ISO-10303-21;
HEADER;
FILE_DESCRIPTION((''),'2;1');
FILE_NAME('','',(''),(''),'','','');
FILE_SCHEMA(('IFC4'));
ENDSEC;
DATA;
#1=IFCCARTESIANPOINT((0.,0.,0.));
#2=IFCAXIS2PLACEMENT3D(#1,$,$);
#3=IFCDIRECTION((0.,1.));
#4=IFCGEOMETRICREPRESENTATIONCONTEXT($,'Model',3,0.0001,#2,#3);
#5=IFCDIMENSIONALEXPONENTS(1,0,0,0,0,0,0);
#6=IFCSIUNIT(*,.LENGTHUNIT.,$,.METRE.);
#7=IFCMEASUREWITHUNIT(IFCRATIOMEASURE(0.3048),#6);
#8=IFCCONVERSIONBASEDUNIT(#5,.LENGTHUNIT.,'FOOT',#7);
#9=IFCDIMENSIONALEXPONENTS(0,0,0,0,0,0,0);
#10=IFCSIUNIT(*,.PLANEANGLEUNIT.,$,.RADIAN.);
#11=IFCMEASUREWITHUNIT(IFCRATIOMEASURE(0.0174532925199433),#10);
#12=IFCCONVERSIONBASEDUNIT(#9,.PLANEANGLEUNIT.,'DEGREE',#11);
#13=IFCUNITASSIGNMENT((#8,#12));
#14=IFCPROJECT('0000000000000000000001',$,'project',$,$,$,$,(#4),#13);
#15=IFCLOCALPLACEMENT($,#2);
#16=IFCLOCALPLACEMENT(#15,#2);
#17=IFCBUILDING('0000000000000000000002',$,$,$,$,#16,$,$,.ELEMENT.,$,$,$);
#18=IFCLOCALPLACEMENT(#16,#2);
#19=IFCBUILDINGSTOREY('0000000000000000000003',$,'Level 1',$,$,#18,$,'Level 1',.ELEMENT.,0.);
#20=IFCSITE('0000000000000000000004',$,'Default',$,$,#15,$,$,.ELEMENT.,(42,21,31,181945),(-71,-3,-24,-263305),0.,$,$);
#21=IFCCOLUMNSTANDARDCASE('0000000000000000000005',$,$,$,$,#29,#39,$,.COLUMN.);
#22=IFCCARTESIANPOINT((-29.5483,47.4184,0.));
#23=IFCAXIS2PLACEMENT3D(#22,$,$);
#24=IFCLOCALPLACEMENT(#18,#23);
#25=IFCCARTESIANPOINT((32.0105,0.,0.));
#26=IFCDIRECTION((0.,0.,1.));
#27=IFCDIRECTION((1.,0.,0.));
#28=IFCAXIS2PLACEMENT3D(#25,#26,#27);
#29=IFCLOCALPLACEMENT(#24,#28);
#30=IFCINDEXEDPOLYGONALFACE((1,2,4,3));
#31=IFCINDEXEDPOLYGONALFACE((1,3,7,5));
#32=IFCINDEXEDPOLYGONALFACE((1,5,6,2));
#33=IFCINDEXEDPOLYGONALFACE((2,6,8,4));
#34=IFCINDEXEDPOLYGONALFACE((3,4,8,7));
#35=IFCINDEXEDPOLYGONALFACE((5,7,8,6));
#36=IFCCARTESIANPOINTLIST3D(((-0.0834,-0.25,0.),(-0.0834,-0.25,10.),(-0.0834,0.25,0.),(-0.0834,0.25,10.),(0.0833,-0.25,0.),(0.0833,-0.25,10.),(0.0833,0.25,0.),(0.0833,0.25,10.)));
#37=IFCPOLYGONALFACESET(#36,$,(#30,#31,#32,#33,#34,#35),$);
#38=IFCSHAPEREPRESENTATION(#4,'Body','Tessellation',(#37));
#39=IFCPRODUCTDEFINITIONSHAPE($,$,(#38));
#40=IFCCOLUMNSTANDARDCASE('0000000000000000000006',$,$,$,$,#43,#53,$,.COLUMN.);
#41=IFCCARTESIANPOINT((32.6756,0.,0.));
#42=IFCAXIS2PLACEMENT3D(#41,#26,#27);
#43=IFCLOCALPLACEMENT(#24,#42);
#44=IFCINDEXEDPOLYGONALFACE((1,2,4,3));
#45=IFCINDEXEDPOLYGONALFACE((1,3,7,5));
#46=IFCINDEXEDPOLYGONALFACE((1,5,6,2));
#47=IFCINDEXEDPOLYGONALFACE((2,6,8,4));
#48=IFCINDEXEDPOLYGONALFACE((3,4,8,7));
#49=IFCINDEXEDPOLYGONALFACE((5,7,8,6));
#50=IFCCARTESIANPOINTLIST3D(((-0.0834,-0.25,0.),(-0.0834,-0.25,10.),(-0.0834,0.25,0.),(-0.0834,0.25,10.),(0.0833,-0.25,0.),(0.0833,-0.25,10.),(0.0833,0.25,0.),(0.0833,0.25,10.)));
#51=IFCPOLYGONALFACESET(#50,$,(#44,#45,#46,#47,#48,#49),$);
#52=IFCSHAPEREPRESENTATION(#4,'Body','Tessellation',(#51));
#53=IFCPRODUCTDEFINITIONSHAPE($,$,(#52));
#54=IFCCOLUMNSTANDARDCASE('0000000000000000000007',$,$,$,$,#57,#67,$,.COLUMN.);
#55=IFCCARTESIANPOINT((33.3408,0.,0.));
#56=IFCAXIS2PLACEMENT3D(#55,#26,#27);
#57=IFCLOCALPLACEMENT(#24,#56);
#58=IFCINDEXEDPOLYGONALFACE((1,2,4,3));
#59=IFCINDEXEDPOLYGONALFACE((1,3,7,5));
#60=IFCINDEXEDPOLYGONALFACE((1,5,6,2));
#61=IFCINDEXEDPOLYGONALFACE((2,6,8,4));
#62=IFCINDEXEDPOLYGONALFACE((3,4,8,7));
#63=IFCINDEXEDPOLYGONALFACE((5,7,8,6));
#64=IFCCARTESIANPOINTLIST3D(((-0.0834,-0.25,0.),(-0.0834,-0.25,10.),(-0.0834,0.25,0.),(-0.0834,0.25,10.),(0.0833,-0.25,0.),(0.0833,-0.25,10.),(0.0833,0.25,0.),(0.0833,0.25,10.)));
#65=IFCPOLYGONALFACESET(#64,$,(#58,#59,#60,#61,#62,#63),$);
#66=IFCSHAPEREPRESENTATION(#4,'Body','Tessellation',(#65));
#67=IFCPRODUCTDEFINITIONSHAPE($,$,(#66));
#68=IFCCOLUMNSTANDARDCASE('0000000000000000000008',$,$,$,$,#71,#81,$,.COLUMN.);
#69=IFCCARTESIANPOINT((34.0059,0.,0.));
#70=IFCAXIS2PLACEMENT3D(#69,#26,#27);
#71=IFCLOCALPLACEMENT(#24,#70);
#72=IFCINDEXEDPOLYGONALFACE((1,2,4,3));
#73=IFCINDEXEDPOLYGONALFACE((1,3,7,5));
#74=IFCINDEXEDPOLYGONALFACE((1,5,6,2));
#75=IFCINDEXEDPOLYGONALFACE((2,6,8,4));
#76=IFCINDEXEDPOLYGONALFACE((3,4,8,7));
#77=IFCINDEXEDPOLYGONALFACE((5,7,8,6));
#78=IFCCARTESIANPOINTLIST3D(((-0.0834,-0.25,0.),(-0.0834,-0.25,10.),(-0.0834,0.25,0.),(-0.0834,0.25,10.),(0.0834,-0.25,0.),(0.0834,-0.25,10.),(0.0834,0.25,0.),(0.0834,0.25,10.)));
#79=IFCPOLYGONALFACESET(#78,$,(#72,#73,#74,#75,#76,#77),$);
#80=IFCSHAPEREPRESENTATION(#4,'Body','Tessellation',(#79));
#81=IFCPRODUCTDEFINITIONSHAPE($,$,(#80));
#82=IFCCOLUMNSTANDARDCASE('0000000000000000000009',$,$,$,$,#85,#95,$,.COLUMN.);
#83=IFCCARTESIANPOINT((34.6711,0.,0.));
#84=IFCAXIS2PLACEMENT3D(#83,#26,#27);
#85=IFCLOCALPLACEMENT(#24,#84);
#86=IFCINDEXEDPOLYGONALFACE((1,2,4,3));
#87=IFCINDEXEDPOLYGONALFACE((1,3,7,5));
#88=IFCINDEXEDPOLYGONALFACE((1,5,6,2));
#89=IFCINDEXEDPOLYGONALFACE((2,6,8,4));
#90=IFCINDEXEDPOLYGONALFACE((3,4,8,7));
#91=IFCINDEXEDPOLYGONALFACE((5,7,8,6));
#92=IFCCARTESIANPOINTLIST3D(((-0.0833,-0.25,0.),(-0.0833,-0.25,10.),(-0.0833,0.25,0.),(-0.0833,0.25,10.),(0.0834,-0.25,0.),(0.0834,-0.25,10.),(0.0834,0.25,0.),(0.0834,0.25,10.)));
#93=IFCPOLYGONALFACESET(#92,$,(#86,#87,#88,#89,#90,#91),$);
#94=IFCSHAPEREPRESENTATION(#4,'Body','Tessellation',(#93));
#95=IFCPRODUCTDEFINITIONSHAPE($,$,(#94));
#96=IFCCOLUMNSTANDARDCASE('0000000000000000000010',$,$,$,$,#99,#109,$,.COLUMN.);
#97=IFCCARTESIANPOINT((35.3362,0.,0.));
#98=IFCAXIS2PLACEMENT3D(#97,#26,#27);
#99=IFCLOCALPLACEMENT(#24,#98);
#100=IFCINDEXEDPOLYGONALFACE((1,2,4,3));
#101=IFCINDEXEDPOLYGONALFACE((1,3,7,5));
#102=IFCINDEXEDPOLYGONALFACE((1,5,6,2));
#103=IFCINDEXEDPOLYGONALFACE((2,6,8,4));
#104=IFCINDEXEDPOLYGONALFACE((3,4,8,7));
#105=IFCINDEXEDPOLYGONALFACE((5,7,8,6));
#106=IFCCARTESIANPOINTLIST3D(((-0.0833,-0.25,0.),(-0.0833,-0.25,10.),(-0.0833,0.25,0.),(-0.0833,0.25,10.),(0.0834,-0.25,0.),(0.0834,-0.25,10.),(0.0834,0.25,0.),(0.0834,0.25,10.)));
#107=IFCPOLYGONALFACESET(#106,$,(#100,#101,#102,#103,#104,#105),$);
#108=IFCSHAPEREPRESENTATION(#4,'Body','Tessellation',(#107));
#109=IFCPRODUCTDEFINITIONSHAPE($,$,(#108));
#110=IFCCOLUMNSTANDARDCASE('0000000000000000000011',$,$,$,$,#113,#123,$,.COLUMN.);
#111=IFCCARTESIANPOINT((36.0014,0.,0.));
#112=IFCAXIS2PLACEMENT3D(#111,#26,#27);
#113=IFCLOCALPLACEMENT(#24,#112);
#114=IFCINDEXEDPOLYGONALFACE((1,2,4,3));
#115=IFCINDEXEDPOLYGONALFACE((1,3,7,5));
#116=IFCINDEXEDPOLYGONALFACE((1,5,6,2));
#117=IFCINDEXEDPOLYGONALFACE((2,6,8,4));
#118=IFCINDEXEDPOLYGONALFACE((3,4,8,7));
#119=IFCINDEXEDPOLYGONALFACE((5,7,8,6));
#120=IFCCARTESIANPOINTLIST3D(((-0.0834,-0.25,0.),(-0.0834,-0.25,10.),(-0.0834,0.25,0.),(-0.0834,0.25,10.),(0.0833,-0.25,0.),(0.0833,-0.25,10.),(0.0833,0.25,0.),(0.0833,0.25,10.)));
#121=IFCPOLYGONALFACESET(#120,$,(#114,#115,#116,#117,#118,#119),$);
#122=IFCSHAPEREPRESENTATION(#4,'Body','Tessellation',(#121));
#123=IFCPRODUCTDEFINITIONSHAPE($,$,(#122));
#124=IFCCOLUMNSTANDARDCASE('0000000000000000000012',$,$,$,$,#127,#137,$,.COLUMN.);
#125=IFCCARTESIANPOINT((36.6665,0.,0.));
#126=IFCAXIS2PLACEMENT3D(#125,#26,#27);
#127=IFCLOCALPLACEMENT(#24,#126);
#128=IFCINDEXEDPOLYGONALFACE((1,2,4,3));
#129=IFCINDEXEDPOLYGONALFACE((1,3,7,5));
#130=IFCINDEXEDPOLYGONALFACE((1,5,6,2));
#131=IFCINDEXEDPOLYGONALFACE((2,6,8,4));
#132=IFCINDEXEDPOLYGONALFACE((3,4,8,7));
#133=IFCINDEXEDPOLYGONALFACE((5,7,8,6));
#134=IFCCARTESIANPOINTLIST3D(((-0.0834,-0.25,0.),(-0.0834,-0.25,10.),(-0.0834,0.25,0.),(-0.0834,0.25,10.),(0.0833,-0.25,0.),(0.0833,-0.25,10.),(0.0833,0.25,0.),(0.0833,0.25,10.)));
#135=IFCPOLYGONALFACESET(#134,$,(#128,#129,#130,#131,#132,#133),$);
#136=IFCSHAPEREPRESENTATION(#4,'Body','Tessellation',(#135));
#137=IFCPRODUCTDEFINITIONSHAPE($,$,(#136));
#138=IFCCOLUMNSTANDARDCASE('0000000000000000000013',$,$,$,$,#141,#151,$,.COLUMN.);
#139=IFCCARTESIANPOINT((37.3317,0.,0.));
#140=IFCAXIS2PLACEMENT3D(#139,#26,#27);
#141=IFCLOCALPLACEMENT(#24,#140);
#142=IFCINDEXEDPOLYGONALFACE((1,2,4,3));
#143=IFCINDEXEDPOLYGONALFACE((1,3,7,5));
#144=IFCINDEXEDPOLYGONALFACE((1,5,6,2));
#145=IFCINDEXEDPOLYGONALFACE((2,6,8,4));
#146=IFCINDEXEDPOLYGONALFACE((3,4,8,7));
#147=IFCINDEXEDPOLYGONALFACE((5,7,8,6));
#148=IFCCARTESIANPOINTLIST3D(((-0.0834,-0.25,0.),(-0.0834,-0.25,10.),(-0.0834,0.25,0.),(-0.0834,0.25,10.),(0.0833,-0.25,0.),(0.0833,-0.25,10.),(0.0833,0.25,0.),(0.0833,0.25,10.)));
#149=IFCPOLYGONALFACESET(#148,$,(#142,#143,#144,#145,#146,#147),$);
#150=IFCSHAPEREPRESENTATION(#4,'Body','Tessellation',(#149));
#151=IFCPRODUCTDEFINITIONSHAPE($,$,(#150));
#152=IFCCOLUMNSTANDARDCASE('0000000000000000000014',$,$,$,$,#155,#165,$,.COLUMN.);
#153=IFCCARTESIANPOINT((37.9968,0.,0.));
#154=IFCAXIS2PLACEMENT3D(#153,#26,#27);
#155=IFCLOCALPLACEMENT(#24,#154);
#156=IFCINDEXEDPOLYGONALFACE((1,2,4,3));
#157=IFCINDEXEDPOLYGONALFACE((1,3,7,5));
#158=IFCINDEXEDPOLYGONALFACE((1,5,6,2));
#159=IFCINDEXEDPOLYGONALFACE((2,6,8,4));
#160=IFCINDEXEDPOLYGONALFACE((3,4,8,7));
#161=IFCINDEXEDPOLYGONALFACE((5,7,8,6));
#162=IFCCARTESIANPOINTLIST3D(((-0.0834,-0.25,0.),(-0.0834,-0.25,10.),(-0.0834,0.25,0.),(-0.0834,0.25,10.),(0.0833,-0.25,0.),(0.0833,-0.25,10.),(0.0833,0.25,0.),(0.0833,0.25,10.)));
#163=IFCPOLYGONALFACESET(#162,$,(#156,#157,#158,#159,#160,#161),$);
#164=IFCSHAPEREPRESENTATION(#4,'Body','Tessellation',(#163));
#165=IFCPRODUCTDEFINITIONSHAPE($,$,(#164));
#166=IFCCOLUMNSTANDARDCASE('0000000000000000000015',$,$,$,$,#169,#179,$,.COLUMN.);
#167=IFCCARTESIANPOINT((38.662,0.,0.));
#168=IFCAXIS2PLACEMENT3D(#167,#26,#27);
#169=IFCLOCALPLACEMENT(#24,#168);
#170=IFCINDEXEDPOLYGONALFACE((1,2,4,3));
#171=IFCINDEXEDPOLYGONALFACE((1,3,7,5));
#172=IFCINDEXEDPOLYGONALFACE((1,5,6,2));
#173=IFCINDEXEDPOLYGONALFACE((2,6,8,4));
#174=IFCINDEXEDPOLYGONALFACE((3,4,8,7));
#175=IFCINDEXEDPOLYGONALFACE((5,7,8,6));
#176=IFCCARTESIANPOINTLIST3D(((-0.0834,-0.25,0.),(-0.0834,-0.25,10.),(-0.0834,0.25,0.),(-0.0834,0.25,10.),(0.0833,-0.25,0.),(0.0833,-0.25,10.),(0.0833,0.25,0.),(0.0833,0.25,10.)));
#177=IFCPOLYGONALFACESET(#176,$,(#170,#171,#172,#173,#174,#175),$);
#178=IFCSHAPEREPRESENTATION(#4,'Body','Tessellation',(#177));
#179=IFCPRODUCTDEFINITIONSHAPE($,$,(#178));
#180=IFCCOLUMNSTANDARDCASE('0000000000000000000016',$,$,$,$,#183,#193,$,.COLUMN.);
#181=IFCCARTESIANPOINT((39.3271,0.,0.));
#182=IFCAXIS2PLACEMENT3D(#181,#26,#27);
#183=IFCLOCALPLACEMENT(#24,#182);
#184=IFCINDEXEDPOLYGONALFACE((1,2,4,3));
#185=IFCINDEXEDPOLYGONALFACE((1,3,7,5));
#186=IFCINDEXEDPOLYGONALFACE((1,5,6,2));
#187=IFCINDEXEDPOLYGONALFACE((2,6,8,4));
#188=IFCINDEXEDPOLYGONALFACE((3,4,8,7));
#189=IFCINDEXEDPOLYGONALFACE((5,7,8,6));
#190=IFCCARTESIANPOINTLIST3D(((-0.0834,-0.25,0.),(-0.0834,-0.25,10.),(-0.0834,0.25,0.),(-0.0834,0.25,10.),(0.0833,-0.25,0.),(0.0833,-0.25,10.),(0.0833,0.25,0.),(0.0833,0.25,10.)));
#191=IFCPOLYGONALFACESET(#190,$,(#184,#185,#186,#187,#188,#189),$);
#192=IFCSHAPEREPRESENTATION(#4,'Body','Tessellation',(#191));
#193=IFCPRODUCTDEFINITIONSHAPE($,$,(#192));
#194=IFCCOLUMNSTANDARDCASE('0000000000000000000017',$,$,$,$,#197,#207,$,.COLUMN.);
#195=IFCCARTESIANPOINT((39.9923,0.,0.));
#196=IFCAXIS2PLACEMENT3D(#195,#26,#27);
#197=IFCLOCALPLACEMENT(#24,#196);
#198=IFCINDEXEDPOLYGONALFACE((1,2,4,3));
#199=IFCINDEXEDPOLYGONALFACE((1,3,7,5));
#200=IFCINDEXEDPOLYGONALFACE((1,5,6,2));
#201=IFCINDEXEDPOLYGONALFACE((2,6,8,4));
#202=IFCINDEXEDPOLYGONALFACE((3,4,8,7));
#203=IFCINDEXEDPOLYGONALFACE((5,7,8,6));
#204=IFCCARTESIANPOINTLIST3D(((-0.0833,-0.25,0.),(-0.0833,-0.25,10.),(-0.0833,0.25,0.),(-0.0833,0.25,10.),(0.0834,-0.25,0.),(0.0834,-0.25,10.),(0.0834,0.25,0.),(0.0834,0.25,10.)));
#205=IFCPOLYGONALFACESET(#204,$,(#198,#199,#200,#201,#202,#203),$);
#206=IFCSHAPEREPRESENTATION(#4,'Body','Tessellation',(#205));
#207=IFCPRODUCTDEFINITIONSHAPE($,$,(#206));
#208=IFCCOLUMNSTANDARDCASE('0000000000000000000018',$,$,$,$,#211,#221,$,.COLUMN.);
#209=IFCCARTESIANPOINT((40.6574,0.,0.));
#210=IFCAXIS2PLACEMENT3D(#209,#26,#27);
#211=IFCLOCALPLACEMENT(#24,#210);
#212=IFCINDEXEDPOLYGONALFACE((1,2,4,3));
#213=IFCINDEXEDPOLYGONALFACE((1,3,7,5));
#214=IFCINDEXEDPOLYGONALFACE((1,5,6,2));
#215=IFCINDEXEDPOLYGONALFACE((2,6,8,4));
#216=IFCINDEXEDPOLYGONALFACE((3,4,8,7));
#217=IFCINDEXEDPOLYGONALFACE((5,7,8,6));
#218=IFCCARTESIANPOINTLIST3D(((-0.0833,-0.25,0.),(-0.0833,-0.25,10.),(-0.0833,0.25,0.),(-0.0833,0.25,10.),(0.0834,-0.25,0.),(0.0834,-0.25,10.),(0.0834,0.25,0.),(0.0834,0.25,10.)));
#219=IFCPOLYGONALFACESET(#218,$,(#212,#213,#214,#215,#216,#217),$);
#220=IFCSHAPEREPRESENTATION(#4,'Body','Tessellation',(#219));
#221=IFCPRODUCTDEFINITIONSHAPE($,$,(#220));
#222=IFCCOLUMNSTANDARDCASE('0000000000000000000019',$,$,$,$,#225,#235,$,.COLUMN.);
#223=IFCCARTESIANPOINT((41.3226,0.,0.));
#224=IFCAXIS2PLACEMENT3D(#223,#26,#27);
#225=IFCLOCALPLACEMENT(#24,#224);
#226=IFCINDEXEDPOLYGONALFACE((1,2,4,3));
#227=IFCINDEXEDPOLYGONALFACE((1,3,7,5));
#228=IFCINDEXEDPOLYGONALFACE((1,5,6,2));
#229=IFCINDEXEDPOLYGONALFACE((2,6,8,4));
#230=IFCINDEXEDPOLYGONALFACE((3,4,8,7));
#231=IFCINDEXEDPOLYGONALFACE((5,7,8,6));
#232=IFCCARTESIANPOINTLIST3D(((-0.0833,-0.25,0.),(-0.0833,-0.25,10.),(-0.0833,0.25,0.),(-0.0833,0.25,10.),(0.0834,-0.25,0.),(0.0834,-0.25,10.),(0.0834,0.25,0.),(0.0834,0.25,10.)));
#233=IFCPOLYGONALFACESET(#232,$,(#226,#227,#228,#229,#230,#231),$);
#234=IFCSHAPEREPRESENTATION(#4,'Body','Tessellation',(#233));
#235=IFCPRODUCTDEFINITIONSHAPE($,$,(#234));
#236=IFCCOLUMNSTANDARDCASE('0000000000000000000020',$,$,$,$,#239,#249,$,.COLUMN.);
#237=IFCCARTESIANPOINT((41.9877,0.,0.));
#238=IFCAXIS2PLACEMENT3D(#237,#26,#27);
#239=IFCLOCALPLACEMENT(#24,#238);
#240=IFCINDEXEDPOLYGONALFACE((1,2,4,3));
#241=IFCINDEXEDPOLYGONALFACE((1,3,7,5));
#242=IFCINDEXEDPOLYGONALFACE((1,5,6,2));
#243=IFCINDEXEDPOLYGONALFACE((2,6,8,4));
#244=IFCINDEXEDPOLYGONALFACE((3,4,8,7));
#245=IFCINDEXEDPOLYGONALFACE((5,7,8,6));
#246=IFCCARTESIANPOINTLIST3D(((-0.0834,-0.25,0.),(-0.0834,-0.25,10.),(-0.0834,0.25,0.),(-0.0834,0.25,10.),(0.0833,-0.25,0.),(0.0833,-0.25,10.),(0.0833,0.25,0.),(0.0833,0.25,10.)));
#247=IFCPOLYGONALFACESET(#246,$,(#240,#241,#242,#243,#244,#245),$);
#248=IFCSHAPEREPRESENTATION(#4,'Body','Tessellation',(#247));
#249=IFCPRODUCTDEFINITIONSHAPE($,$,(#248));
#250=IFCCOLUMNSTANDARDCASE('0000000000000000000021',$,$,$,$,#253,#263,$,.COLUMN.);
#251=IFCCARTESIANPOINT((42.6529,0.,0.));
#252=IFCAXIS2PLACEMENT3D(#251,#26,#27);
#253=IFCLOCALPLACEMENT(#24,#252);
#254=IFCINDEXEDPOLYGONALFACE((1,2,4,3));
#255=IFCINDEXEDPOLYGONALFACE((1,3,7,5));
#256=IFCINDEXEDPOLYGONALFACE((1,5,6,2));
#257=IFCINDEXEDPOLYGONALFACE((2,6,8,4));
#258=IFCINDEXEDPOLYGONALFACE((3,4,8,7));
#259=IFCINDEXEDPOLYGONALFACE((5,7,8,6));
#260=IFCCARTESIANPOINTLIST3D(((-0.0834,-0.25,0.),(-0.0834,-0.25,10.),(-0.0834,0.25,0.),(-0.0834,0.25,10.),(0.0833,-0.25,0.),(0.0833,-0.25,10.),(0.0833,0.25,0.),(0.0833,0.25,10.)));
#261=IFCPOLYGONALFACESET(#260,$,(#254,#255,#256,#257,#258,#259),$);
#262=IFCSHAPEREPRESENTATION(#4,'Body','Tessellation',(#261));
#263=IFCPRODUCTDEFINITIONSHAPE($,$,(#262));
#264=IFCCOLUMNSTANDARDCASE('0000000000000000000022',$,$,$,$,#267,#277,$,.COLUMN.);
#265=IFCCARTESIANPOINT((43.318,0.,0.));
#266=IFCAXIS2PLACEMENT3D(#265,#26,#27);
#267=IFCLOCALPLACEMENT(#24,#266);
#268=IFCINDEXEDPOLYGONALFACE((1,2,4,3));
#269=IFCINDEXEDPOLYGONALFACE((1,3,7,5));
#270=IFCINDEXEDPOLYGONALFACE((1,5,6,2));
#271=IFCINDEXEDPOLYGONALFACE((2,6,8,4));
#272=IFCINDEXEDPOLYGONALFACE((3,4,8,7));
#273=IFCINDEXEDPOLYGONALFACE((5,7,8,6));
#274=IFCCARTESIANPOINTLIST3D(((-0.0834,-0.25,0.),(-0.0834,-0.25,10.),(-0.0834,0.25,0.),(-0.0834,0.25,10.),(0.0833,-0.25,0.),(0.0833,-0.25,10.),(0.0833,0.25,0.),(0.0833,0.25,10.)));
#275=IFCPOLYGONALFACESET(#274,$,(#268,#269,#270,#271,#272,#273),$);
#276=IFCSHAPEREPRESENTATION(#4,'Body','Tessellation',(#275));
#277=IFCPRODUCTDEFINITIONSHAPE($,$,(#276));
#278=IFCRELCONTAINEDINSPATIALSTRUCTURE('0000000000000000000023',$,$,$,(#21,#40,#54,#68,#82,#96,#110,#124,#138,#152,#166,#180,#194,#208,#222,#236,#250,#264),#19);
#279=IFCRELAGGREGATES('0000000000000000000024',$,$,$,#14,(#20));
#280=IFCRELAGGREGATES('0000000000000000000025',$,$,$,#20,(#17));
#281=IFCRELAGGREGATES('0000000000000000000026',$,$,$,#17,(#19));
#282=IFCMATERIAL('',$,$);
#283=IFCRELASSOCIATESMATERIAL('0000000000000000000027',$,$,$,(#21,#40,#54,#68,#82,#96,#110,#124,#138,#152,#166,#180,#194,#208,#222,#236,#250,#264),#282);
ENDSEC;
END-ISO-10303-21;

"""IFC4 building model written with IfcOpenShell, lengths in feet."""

from ifc_helpers import new_model, entity, si_unit, converted_unit, direction, frame, origin, place, context, project, spatial, rectangle, extrude, material, element, save


model = new_model("IFC4")

# Units and contexts
model_context = context("Model", 3, precision=0.0001, world=origin(), true_north=direction((0.0, 1.0)))
ifc_project = project(units=[converted_unit("LENGTHUNIT", "FOOT", entity("IfcRatioMeasure", 0.3048), si_unit("LENGTHUNIT", "METRE"), dimensions=[1, 0, 0, 0, 0, 0, 0]), converted_unit("PLANEANGLEUNIT", "DEGREE", entity("IfcRatioMeasure", 0.0174532925199433), si_unit("PLANEANGLEUNIT", "RADIAN"), dimensions=[0, 0, 0, 0, 0, 0, 0])], contexts=[model_context])

# Site, building, storey
site_placement = place(None, origin())
site = spatial("IfcSite", under=ifc_project, at=site_placement, Name="Default", CompositionType="ELEMENT", RefLatitude=(42, 21, 31, 181945), RefLongitude=(-71, -3, -24, -263305), RefElevation=0.0)
building_placement = place(site_placement, origin())
building = spatial("IfcBuilding", under=site, at=building_placement, CompositionType="ELEMENT")
storey_placement = place(building_placement, origin())
storey = spatial("IfcBuildingStorey", under=building, at=storey_placement, Name="Level 1", LongName="Level 1", CompositionType="ELEMENT", Elevation=0.0)

# Columns
ifc_material = material(Name="")
placement = place(storey_placement, frame((-29.5483, 47.4184, 0.0)))
for number, where, z_axis, x_axis in (
    (1, (32.0105, 0.0, 0.0), (0.0, 0.0, 1.0), (1.0, 0.0, 0.0)),
    (2, (32.6756, 0.0, 0.0), (0.0, 0.0, 1.0), (1.0, 0.0, 0.0)),
    (3, (33.3408, 0.0, 0.0), (0.0, 0.0, 1.0), (1.0, 0.0, 0.0)),
    (4, (34.0059, 0.0, 0.0), (0.0, 0.0, 1.0), (1.0, 0.0, 0.0)),
    (5, (34.6711, 0.0, 0.0), (0.0, 0.0, 1.0), (1.0, 0.0, 0.0)),
    (6, (35.3362, 0.0, 0.0), (0.0, 0.0, 1.0), (1.0, 0.0, 0.0)),
    (7, (36.0014, 0.0, 0.0), (0.0, 0.0, 1.0), (1.0, 0.0, 0.0)),
    (8, (36.6665, 0.0, 0.0), (0.0, 0.0, 1.0), (1.0, 0.0, 0.0)),
    (9, (37.3317, 0.0, 0.0), (0.0, 0.0, 1.0), (1.0, 0.0, 0.0)),
    (10, (37.9968, 0.0, 0.0), (0.0, 0.0, 1.0), (1.0, 0.0, 0.0)),
    (11, (38.662, 0.0, 0.0), (0.0, 0.0, 1.0), (1.0, 0.0, 0.0)),
    (12, (39.3271, 0.0, 0.0), (0.0, 0.0, 1.0), (1.0, 0.0, 0.0)),
    (13, (39.9923, 0.0, 0.0), (0.0, 0.0, 1.0), (1.0, 0.0, 0.0)),
    (14, (40.6574, 0.0, 0.0), (0.0, 0.0, 1.0), (1.0, 0.0, 0.0)),
    (15, (41.3226, 0.0, 0.0), (0.0, 0.0, 1.0), (1.0, 0.0, 0.0)),
    (16, (41.9877, 0.0, 0.0), (0.0, 0.0, 1.0), (1.0, 0.0, 0.0)),
    (17, (42.6529, 0.0, 0.0), (0.0, 0.0, 1.0), (1.0, 0.0, 0.0)),
    (18, (43.318, 0.0, 0.0), (0.0, 0.0, 1.0), (1.0, 0.0, 0.0)),
):
    element("IfcColumnStandardCase", number, at=place(placement, frame(where, z_axis=z_axis, x_axis=x_axis)), inside=storey, material=ifc_material, PredefinedType="COLUMN", context=model_context, shape_type="SweptSolid", body=[
        extrude(rectangle(XDim=0.1667, YDim=0.5), origin(), (0.0, 0.0, 1.0), 10.0),
    ])

save(model, "model.ifc")
